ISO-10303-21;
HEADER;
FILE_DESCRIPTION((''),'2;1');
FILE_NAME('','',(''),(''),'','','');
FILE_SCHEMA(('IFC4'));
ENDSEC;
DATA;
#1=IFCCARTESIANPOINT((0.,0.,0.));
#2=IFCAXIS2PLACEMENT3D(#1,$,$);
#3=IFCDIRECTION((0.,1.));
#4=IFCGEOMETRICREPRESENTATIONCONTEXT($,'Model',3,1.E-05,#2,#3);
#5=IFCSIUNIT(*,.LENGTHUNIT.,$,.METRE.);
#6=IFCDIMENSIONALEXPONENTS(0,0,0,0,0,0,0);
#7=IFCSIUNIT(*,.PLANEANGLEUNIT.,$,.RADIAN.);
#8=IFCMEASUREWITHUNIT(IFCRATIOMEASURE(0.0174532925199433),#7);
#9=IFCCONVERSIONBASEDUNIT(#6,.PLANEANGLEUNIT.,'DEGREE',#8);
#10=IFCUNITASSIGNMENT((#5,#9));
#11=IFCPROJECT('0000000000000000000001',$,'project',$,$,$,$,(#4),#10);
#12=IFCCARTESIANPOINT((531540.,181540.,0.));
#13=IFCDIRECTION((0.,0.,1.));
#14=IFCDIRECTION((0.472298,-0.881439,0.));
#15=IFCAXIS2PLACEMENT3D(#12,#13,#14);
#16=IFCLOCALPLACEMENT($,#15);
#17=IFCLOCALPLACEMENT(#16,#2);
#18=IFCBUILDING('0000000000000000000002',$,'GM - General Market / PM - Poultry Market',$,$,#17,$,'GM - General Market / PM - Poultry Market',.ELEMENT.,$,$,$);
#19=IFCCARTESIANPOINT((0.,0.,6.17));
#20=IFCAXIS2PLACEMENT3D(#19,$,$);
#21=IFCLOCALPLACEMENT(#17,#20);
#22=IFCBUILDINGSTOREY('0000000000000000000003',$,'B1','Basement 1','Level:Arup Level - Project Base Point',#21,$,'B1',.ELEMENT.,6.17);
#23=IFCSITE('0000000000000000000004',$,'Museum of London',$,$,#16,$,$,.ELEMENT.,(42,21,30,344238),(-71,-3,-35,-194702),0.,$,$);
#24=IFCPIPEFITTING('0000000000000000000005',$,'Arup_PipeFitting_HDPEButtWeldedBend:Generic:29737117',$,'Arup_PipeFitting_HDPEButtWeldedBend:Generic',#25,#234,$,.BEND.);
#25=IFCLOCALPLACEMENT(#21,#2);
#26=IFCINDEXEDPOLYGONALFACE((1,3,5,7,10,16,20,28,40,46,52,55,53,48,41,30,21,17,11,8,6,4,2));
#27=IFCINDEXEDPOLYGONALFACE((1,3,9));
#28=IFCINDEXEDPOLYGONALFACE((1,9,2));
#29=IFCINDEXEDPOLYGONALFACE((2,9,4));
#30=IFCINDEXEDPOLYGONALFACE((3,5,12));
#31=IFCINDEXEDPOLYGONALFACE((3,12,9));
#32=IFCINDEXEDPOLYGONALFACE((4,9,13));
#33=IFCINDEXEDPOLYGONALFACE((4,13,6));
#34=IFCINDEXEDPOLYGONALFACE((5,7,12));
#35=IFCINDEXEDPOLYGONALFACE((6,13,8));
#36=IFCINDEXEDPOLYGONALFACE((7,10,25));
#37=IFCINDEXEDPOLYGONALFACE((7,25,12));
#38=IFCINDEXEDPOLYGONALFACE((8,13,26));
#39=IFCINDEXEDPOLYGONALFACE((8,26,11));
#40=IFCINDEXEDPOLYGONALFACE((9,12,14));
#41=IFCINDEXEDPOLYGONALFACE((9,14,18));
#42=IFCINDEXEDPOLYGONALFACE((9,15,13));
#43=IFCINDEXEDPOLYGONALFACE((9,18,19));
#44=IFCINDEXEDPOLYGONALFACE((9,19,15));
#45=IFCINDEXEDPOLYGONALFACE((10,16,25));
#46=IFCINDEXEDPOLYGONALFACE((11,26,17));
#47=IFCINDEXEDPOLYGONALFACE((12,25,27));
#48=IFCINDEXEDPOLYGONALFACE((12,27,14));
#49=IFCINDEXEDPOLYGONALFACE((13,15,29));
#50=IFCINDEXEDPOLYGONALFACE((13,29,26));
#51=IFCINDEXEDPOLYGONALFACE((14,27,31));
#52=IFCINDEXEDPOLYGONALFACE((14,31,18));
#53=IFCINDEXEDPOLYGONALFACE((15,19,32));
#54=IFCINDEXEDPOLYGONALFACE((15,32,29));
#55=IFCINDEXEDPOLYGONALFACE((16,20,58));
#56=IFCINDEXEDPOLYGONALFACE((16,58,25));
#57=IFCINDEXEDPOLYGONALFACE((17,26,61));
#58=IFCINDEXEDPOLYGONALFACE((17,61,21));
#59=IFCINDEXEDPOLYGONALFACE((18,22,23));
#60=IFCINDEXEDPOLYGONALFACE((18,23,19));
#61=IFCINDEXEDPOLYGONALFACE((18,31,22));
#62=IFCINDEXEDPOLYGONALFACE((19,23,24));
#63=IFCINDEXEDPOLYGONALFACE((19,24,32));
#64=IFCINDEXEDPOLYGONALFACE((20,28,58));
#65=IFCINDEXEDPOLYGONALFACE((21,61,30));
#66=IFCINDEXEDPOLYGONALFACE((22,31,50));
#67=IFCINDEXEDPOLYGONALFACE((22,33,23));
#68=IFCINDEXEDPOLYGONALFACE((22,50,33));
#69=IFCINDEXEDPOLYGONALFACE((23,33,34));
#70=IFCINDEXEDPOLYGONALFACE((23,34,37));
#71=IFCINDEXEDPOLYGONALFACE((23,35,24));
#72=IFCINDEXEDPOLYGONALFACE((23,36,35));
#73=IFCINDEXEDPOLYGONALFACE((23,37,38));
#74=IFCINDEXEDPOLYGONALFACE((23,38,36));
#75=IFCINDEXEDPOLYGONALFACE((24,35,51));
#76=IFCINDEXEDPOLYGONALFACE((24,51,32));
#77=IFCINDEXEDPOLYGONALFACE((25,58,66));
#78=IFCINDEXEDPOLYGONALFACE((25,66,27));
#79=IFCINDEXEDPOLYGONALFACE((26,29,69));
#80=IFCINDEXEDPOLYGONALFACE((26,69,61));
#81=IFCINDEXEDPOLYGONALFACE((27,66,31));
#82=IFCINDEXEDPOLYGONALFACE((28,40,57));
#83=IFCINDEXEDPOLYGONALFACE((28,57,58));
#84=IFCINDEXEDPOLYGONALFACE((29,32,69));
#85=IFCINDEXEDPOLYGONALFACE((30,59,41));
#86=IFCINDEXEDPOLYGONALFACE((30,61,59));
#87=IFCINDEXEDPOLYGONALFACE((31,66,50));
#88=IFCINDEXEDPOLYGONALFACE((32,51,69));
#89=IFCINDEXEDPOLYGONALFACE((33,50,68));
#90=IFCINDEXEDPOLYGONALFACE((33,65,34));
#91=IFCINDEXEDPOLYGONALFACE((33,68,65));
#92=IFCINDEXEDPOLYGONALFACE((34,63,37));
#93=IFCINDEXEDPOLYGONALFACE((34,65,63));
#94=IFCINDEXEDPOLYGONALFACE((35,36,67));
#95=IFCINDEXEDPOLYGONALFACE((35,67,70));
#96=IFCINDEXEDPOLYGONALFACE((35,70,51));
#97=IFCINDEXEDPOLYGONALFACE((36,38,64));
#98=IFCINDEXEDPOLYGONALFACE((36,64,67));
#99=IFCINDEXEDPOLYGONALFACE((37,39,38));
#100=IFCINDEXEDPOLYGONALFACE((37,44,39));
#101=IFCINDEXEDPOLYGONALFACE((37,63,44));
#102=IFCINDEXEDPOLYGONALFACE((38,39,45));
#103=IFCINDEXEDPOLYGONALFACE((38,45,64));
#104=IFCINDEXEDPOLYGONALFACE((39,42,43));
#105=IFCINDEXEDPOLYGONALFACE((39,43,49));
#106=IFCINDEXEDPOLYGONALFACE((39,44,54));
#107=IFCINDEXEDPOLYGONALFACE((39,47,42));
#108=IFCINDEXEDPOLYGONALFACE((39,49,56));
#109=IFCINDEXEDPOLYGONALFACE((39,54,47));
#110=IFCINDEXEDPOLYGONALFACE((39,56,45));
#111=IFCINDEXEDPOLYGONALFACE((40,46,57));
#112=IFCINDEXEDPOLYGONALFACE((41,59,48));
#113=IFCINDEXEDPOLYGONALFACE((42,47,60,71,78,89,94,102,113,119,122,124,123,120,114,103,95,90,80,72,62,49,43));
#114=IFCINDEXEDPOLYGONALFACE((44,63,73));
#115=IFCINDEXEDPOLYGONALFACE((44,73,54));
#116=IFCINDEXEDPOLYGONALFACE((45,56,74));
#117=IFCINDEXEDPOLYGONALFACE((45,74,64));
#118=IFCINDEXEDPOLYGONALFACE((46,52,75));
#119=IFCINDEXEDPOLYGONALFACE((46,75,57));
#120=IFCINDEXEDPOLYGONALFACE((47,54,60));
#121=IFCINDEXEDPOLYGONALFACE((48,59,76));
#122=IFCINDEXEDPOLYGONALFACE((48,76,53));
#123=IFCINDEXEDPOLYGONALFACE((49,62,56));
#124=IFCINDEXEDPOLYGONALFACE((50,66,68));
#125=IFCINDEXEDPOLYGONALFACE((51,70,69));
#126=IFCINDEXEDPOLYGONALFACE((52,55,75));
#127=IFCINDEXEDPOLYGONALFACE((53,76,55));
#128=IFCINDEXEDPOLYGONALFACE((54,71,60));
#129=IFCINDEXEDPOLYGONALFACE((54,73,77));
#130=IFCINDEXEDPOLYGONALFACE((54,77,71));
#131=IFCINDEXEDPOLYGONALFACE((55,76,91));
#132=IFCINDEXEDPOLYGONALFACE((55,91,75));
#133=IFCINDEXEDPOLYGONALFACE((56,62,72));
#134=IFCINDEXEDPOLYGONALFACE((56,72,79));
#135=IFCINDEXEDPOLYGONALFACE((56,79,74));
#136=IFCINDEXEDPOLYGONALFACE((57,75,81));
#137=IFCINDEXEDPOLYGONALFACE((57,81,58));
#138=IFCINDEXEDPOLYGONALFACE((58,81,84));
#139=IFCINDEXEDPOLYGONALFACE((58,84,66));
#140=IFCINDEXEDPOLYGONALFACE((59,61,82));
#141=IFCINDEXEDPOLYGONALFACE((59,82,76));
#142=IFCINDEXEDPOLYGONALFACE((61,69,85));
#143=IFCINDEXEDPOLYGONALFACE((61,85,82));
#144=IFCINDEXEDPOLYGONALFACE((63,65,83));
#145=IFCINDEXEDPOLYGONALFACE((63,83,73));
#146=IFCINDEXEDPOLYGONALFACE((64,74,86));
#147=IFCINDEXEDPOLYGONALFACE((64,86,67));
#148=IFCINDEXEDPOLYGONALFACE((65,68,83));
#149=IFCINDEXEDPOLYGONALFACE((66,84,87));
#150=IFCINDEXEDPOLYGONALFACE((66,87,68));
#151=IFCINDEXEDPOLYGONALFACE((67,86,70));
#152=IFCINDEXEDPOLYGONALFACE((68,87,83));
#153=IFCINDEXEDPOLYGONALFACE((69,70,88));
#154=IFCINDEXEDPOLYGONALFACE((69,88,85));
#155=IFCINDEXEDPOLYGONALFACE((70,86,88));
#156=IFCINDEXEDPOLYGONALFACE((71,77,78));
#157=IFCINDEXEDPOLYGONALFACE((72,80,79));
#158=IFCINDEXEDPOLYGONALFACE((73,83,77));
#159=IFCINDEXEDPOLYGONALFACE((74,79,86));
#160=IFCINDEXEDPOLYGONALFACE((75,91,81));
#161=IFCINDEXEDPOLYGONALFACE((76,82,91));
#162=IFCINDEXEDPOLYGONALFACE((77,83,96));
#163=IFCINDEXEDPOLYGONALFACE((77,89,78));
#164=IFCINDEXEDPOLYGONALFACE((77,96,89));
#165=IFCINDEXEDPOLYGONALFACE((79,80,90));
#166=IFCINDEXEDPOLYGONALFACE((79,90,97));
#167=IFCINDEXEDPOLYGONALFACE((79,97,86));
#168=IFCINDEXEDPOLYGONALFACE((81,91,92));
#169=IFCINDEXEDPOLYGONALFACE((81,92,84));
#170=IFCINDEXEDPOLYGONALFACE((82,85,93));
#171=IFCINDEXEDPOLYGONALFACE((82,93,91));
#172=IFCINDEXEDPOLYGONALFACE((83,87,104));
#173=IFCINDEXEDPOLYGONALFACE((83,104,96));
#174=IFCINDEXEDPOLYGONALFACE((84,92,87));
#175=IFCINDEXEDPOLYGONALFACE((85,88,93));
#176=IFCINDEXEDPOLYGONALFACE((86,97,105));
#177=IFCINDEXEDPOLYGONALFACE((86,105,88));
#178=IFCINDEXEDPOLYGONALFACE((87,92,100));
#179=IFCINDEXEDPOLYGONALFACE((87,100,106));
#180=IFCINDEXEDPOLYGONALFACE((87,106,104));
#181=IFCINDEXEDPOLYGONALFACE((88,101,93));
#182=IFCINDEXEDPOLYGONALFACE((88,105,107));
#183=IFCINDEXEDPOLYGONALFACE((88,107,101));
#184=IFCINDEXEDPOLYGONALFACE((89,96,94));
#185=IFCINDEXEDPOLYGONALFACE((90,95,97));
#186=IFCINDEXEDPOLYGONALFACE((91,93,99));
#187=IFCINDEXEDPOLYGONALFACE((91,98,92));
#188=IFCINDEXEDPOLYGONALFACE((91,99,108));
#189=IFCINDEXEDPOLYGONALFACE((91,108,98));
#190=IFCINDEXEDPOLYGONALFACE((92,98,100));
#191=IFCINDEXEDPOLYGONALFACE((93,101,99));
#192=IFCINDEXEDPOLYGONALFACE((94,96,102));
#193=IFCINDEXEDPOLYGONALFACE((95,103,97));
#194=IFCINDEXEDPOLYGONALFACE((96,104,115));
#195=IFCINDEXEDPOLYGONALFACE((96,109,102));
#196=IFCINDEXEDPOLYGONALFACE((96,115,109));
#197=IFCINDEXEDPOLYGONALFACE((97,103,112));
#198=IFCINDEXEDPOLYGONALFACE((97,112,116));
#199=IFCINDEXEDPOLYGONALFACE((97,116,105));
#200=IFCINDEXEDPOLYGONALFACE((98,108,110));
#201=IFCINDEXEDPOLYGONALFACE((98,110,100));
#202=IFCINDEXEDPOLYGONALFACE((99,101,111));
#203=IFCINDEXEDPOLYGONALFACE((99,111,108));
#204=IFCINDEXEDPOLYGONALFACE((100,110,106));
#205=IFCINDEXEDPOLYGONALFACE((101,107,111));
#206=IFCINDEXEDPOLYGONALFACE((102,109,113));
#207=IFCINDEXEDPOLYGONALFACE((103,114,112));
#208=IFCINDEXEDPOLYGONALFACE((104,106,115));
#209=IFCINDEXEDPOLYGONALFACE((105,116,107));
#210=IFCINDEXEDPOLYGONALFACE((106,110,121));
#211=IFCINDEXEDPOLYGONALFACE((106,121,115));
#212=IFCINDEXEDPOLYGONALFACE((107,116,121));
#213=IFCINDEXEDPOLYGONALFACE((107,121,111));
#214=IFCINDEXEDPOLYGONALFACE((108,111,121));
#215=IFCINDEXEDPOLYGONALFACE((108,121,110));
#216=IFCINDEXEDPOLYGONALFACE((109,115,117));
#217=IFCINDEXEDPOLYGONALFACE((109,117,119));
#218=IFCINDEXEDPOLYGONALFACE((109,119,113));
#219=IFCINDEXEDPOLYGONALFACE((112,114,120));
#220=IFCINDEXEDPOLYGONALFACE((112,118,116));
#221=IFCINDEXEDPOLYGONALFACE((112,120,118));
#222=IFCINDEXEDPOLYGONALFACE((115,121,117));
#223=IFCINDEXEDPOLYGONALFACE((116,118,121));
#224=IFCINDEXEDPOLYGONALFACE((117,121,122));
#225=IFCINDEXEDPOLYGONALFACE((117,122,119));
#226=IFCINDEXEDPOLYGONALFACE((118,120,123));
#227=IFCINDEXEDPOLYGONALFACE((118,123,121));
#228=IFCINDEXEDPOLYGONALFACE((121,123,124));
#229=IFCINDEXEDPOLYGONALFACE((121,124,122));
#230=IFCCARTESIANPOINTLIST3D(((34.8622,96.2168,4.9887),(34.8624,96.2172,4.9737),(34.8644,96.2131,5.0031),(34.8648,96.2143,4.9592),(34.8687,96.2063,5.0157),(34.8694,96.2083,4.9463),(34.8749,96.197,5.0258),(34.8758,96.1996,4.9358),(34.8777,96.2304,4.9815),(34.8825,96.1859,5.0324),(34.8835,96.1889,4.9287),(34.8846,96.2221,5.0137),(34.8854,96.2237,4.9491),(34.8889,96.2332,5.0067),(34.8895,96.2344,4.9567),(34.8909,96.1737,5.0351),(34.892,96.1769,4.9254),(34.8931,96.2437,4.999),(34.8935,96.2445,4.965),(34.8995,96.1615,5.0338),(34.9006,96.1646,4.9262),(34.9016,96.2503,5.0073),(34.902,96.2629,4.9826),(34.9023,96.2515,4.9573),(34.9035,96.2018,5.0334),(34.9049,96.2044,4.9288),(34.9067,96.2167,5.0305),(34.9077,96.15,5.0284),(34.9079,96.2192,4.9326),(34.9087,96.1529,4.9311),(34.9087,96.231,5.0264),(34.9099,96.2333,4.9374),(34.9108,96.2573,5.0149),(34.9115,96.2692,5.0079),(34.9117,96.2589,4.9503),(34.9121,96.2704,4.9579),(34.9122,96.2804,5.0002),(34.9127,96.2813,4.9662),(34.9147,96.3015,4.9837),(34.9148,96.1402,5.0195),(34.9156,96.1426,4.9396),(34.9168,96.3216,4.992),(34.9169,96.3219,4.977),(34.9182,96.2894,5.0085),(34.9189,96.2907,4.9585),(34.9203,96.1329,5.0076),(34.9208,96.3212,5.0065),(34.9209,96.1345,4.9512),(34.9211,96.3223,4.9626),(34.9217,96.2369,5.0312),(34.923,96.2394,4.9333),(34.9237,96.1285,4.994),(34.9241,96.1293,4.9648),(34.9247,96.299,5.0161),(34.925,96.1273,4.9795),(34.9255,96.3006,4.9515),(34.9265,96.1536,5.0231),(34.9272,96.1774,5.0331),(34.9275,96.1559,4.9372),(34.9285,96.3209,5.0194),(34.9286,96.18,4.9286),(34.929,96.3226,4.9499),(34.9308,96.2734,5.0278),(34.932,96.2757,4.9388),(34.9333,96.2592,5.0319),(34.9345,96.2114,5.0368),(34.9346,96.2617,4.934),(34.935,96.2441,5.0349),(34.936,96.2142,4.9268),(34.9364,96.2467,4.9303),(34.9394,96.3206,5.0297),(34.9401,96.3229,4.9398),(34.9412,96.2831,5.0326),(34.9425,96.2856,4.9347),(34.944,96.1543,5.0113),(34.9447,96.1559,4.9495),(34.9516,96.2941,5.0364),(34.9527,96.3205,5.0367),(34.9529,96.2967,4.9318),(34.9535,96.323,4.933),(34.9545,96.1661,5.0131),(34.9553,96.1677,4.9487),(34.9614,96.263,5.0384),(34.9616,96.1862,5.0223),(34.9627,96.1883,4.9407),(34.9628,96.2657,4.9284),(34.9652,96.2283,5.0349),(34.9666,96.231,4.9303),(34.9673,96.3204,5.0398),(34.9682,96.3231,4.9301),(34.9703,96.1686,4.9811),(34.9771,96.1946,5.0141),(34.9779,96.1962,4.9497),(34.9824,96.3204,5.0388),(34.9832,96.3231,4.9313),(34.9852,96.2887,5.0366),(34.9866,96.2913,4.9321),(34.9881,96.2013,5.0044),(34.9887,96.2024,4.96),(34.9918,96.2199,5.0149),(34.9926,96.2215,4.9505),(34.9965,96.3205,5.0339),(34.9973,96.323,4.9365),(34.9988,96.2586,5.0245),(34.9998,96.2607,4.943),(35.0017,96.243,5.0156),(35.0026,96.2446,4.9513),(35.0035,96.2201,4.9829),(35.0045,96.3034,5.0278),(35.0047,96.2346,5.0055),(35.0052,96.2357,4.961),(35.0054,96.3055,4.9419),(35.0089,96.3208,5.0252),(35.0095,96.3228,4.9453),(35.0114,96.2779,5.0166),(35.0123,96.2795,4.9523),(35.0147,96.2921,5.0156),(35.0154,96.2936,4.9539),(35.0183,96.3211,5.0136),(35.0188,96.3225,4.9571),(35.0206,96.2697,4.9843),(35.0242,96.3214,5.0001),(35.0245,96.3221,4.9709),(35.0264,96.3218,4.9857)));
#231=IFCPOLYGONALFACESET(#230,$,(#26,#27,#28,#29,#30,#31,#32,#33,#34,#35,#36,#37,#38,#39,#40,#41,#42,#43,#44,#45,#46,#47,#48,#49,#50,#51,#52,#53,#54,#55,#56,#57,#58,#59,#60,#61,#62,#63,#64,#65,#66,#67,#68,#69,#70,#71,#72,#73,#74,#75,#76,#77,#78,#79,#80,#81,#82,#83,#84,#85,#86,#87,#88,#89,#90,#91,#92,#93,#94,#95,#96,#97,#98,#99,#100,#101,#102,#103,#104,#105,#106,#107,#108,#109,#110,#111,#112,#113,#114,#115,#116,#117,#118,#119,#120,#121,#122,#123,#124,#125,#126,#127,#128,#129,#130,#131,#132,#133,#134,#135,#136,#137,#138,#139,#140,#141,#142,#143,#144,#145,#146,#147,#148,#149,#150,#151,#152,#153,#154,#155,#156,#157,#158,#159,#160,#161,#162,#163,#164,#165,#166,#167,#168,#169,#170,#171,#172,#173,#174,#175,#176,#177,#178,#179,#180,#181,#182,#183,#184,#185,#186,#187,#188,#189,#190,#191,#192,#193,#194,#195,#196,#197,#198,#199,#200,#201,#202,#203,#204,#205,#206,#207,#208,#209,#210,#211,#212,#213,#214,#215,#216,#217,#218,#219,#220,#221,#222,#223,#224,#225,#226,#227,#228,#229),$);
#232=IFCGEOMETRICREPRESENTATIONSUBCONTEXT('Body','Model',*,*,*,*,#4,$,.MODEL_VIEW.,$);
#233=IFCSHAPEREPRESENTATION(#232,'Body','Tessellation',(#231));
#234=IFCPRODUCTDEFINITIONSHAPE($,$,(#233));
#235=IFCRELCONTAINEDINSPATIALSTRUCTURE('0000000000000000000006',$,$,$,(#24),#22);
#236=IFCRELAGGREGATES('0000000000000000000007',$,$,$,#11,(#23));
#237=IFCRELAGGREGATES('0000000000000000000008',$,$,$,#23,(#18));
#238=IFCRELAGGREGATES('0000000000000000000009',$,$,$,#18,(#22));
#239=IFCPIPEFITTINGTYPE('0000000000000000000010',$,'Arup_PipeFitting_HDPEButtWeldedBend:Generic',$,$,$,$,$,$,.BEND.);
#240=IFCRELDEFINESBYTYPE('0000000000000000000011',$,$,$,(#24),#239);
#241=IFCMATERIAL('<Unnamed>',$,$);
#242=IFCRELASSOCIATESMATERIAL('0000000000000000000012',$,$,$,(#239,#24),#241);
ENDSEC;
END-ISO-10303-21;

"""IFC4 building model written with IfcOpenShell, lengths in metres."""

from ifc_helpers import new_model, entity, si_unit, converted_unit, direction, frame, origin, place, context, subcontext, project, spatial, source, transform, mapped, material, type_object, type_shapes, element, save


model = new_model("IFC4")

# Units and contexts
model_context = context("Model", 3, precision=1e-05, world=origin(), true_north=direction((0.0, 1.0)))
body_context = subcontext(model_context, "Body", "Model", "MODEL_VIEW")
ifc_project = project(units=[si_unit("LENGTHUNIT", "METRE"), converted_unit("PLANEANGLEUNIT", "DEGREE", entity("IfcRatioMeasure", 0.0174532925199433), si_unit("PLANEANGLEUNIT", "RADIAN"), dimensions=[0, 0, 0, 0, 0, 0, 0])], contexts=[model_context])

# Site, building, storey
site_placement = place(None, frame((531540.0, 181540.0, 0.0), z_axis=(0.0, 0.0, 1.0), x_axis=(0.472298, -0.881439, 0.0)))
site = spatial("IfcSite", under=ifc_project, at=site_placement, Name="Museum of London", CompositionType="ELEMENT", RefLatitude=(42, 21, 30, 344238), RefLongitude=(-71, -3, -35, -194702), RefElevation=0.0)
building_placement = place(site_placement, origin())
building = spatial("IfcBuilding", under=site, at=building_placement, Name="GM - General Market / PM - Poultry Market", LongName="GM - General Market / PM - Poultry Market", CompositionType="ELEMENT")
storey_placement = place(building_placement, frame((0.0, 0.0, 6.17)))
storey = spatial("IfcBuildingStorey", under=building, at=storey_placement, Name="B1", Description="Basement 1", ObjectType="Level:Arup Level - Project Base Point", LongName="B1", CompositionType="ELEMENT", Elevation=6.17)

# Shared definitions
ifc_material_1 = material(Name="<Unnamed>")

# Pipe fitting
pipe_fitting_type_1 = type_object("IfcPipeFittingType", Name="Arup_PipeFitting_HDPEButtWeldedBend:Generic", PredefinedType="BEND", material=ifc_material_1)
ifc_direction_1 = entity("IfcDirection", [0.0, 0.0, 1.0])
trimmed_curve_1 = entity("IfcTrimmedCurve", entity("IfcCircle", entity("IfcAxis2Placement2D", entity("IfcCartesianPoint", [-0.1824, 0.0]), entity("IfcDirection", [0.0, 1.0])), 0.1824), [entity("IfcParameterValue", 270.0)], [entity("IfcParameterValue", 325.033099)], True, "PARAMETER")
shared_shape_1 = source(origin(), body_context, "Body", "AdvancedSweptSolid", [
    entity("IfcSurfaceCurveSweptAreaSolid", entity("IfcCircleProfileDef", "AREA", None, entity("IfcAxis2Placement2D", entity("IfcCartesianPoint", [0.0, 0.0]), entity("IfcDirection", [1.0, 0.0])), 0.055), entity("IfcAxis2Placement3D", entity("IfcCartesianPoint", [-0.095, 0.0, 0.0]), ifc_direction_1, entity("IfcDirection", [0.0, -1.0, 0.0])), trimmed_curve_1, 0.0, 55.0331, entity("IfcSurfaceOfLinearExtrusion", entity("IfcArbitraryOpenProfileDef", "CURVE", None, trimmed_curve_1), entity("IfcAxis2Placement3D", entity("IfcCartesianPoint", [0.0, 0.0, -0.3048])), ifc_direction_1, 1.0)),
])
type_shapes(pipe_fitting_type_1, [shared_shape_1])
pipe_fitting_1_placement = place(storey_placement, frame((34.9714, 96.2268, 4.9826), z_axis=(-0.013074, -0.024953, 0.999603), x_axis=(0.819413, 0.572657, 0.025012)))
element("IfcPipeFitting", 1, at=pipe_fitting_1_placement, inside=storey, type_object=pipe_fitting_type_1, material=ifc_material_1, Name="Arup_PipeFitting_HDPEButtWeldedBend:Generic:29737117", ObjectType="Arup_PipeFitting_HDPEButtWeldedBend:Generic", PredefinedType="BEND", context=body_context, shape_type="MappedRepresentation", body=[
    mapped(shared_shape_1, transform((0.0, 0.0, 0.0), scale=1.0)),
])

save(model, "model.ifc")
